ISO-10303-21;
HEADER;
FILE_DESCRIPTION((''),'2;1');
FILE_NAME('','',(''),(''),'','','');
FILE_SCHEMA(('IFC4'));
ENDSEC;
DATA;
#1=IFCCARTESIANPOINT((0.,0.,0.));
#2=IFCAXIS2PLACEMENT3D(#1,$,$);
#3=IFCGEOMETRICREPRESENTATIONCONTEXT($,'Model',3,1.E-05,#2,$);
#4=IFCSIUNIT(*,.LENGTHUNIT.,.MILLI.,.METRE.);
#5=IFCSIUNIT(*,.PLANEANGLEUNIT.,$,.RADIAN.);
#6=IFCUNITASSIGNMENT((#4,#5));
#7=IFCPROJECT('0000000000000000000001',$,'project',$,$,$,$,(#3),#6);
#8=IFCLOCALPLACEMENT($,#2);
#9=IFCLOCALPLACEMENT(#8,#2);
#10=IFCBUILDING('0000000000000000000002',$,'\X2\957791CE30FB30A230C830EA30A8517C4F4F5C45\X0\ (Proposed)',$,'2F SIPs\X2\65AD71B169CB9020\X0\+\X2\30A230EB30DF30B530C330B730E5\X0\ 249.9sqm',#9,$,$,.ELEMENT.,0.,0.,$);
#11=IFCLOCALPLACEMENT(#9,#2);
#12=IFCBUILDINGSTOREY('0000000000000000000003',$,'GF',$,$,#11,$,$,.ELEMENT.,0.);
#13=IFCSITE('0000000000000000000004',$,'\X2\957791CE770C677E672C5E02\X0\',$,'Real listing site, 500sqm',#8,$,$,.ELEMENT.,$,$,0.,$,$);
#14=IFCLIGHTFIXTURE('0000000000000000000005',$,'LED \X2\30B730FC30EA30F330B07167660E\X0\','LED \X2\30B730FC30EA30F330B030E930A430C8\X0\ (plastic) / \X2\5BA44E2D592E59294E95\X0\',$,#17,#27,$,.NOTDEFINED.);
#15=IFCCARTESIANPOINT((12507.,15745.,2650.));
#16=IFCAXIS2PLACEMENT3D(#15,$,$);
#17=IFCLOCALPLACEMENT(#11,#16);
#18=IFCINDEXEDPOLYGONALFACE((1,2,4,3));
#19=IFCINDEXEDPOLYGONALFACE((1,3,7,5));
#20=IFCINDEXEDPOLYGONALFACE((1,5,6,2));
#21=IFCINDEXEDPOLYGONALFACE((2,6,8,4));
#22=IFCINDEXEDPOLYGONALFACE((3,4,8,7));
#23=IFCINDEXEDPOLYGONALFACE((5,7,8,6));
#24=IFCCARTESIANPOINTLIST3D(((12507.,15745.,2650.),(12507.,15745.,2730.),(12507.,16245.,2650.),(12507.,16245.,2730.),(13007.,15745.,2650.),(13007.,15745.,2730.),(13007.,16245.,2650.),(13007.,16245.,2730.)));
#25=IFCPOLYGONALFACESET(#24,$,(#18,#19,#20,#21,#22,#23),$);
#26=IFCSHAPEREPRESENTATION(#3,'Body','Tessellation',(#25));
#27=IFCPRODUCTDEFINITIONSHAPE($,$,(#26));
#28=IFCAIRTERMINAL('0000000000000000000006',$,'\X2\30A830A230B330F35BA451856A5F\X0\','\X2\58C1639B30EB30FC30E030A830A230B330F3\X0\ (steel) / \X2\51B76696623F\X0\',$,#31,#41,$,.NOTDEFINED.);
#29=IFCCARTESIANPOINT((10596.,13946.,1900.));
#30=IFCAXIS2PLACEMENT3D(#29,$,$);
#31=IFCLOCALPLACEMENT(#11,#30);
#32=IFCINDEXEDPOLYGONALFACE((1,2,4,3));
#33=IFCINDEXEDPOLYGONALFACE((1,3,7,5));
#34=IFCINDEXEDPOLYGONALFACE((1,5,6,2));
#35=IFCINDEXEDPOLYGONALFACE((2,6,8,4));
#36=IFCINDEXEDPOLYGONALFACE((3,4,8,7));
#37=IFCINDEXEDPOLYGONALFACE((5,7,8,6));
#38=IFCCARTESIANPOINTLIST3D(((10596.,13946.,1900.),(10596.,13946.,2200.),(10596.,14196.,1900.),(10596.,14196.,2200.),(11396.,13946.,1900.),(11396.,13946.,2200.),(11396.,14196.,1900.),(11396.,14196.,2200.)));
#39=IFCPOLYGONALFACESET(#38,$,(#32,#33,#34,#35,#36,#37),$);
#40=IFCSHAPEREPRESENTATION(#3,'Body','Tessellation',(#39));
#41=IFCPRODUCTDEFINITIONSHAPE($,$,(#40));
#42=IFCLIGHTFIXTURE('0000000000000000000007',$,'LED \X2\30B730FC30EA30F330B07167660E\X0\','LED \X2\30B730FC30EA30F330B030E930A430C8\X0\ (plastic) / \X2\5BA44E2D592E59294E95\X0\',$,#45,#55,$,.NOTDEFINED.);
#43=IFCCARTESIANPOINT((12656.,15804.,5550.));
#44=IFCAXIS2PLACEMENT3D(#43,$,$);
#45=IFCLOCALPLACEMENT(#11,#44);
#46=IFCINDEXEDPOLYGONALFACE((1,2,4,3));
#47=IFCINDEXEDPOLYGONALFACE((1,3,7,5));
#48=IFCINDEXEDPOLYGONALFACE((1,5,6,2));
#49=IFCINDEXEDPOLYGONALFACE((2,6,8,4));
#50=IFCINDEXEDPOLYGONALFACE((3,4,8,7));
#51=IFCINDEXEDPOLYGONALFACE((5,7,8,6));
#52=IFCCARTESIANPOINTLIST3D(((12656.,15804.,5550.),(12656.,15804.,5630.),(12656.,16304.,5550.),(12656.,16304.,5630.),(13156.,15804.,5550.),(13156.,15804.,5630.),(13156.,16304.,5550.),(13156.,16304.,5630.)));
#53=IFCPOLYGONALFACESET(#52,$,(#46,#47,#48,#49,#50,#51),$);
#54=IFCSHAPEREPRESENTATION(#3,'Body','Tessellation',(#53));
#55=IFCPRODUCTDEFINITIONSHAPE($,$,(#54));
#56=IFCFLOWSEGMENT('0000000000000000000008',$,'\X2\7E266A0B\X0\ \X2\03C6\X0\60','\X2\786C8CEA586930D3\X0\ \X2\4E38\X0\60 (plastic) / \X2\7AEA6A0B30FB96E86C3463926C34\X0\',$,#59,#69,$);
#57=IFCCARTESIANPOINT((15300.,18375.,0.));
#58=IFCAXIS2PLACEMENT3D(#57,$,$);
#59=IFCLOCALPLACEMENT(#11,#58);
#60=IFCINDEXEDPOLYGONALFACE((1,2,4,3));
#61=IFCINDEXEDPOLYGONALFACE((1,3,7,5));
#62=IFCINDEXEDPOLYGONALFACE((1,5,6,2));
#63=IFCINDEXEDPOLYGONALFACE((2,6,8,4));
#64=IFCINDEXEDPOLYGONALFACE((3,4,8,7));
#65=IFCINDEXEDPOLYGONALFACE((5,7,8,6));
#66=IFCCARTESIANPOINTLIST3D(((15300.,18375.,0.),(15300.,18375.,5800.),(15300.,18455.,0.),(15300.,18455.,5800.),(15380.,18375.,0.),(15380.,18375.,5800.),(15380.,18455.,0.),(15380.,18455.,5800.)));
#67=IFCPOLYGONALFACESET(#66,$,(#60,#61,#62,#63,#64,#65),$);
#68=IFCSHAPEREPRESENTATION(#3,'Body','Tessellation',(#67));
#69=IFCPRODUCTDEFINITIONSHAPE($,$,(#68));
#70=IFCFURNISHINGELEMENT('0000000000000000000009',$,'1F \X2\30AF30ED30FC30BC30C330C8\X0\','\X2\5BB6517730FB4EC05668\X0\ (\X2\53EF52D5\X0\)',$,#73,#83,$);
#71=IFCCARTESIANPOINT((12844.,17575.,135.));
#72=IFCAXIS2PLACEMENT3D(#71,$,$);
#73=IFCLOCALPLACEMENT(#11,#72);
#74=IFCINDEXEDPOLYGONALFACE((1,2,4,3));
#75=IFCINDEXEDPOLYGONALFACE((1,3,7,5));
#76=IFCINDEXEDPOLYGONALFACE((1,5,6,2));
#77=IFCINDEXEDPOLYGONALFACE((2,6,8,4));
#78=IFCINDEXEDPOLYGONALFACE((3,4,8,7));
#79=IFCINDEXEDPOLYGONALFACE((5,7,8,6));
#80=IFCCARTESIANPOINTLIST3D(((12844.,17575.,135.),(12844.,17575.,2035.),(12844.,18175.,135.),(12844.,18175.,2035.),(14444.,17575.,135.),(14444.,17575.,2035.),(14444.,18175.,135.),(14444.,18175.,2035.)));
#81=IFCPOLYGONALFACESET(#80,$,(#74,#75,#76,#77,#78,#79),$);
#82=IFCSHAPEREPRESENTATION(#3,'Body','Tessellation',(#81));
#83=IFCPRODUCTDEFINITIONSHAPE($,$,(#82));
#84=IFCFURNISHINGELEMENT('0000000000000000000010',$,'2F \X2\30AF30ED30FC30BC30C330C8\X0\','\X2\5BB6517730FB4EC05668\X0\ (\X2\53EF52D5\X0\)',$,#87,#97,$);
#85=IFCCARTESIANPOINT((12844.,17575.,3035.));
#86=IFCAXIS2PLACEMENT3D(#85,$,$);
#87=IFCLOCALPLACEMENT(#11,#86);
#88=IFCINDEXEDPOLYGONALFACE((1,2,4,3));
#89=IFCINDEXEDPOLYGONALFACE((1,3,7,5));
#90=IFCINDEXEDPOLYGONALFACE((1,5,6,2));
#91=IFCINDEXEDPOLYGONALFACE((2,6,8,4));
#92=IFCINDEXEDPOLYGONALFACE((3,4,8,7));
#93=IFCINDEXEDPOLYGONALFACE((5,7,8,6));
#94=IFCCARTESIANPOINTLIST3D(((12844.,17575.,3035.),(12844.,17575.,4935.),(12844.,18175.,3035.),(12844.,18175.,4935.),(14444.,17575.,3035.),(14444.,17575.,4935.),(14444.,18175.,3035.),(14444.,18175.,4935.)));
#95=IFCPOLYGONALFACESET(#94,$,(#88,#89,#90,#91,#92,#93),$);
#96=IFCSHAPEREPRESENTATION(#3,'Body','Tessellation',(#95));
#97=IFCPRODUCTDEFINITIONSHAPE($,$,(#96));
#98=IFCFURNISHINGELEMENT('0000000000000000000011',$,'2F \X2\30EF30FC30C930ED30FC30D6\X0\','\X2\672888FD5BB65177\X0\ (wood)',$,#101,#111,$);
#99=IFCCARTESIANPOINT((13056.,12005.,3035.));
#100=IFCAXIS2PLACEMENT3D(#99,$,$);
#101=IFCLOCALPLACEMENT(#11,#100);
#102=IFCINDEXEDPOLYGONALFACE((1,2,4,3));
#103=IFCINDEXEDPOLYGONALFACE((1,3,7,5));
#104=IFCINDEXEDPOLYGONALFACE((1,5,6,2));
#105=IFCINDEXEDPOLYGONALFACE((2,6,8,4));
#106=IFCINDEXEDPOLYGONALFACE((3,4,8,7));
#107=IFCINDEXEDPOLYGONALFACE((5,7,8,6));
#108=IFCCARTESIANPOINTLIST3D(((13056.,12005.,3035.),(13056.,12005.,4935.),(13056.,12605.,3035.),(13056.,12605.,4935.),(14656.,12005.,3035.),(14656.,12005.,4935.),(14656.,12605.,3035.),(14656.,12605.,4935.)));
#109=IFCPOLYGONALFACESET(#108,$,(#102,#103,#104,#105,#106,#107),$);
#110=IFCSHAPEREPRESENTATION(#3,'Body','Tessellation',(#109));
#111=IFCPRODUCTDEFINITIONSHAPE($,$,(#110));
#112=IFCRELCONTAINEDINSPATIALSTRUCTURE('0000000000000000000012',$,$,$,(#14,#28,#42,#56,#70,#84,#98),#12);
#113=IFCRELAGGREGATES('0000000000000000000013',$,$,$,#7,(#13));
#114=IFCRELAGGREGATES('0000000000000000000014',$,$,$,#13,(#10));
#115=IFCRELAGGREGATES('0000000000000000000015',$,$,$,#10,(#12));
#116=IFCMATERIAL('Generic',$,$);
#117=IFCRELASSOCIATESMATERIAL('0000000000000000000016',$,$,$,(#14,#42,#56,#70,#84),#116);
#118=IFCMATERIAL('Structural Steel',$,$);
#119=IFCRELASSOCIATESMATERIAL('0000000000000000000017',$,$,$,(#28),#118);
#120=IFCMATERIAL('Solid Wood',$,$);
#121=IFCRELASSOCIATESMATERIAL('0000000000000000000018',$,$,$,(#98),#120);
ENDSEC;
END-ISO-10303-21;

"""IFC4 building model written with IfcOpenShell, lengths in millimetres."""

from ifc_helpers import new_model, si_unit, frame, frame_2d, origin, place, context, project, spatial, rectangle, extrude, material, element, save


model = new_model("IFC4")

# Units and contexts
model_context = context("Model", 3, precision=1e-05, world=origin())
ifc_project = project(units=[si_unit("LENGTHUNIT", "METRE", prefix="MILLI"), si_unit("PLANEANGLEUNIT", "RADIAN")], contexts=[model_context])

# Site, building, storey
site_placement = place(None, origin())
site = spatial("IfcSite", under=ifc_project, at=site_placement, Name="長野県松本市", ObjectType="Real listing site, 500sqm", CompositionType="ELEMENT", RefElevation=0.0)
building_placement = place(site_placement, origin())
building = spatial("IfcBuilding", under=site, at=building_placement, Name="長野・アトリエ兼住居 (Proposed)", ObjectType="2F SIPs断熱構造+アルミサッシュ 249.9sqm", CompositionType="ELEMENT", ElevationOfRefHeight=0.0, ElevationOfTerrain=0.0)
storey_placement = place(building_placement, origin())
storey = spatial("IfcBuildingStorey", under=building, at=storey_placement, Name="GF", CompositionType="ELEMENT", Elevation=0.0)

# Shared definitions
ifc_material_1 = material(Name="Solid Wood")

# Shared definitions
ifc_material_2 = material(Name="Structural Steel")

# Shared definitions
ifc_material_3 = material(Name="Generic")

# Light fixture
light_fixture_1_placement = place(storey_placement, frame((12507.0, 15745.0, 2650.0)))
element("IfcLightFixture", 1, at=light_fixture_1_placement, inside=storey, material=ifc_material_3, Name="LED シーリング照明", Description="LED シーリングライト (plastic) / 室中央天井", PredefinedType="NOTDEFINED", context=model_context, shape_type="SweptSolid", body=[
    extrude(rectangle(XDim=500.0, YDim=500.0, at=frame_2d((250.0, 250.0))), frame((12507.0, 15745.0, 2650.0)), (0.0, 0.0, 1.0), 80.0),
])

# Air terminal
air_terminal_placement = place(storey_placement, frame((10596.0, 13946.0, 1900.0)))
element("IfcAirTerminal", 2, at=air_terminal_placement, inside=storey, material=ifc_material_2, Name="エアコン室内機", Description="壁掛ルームエアコン (steel) / 冷暖房", PredefinedType="NOTDEFINED", context=model_context, shape_type="SweptSolid", body=[
    extrude(rectangle(XDim=800.0, YDim=250.0, at=frame_2d((400.0, 125.0))), frame((10596.0, 13946.0, 1900.0)), (0.0, 0.0, 1.0), 300.0),
])

# Light fixture
light_fixture_2_placement = place(storey_placement, frame((12656.0, 15804.0, 5550.0)))
element("IfcLightFixture", 3, at=light_fixture_2_placement, inside=storey, material=ifc_material_3, Name="LED シーリング照明", Description="LED シーリングライト (plastic) / 室中央天井", PredefinedType="NOTDEFINED", context=model_context, shape_type="SweptSolid", body=[
    extrude(rectangle(XDim=500.0, YDim=500.0, at=frame_2d((250.0, 250.0))), frame((12656.0, 15804.0, 5550.0)), (0.0, 0.0, 1.0), 80.0),
])

# Flow segment
flow_segment_placement = place(storey_placement, frame((15300.0, 18375.0, 0.0)))
element("IfcFlowSegment", 4, at=flow_segment_placement, inside=storey, material=ifc_material_3, Name="縦樋 φ60", Description="硬質塩ビ 丸60 (plastic) / 竪樋・雨水排水", context=model_context, shape_type="SweptSolid", body=[
    extrude(rectangle(XDim=80.0, YDim=80.0, at=frame_2d((40.0, 40.0))), frame((15300.0, 18375.0, 0.0)), (0.0, 0.0, 1.0), 5800.0),
])

# Furnishing elements
furnishing_1_placement = place(storey_placement, frame((12844.0, 17575.0, 135.0)))
element("IfcFurnishingElement", 5, at=furnishing_1_placement, inside=storey, material=ifc_material_3, Name="1F クローゼット", Description="家具・什器 (可動)", context=model_context, shape_type="SweptSolid", body=[
    extrude(rectangle(XDim=1600.0, YDim=600.0, at=frame_2d((800.0, 300.0))), frame((12844.0, 17575.0, 135.0)), (0.0, 0.0, 1.0), 1900.0),
])
furnishing_2_placement = place(storey_placement, frame((12844.0, 17575.0, 3035.0)))
element("IfcFurnishingElement", 6, at=furnishing_2_placement, inside=storey, material=ifc_material_3, Name="2F クローゼット", Description="家具・什器 (可動)", context=model_context, shape_type="SweptSolid", body=[
    extrude(rectangle(XDim=1600.0, YDim=600.0, at=frame_2d((800.0, 300.0))), frame((12844.0, 17575.0, 3035.0)), (0.0, 0.0, 1.0), 1900.0),
])
furnishing_3_placement = place(storey_placement, frame((13056.0, 12005.0, 3035.0)))
element("IfcFurnishingElement", 7, at=furnishing_3_placement, inside=storey, material=ifc_material_1, Name="2F ワードローブ", Description="木製家具 (wood)", context=model_context, shape_type="SweptSolid", body=[
    extrude(rectangle(XDim=1600.0, YDim=600.0, at=frame_2d((800.0, 300.0))), frame((13056.0, 12005.0, 3035.0)), (0.0, 0.0, 1.0), 1900.0),
])

save(model, "model.ifc")
